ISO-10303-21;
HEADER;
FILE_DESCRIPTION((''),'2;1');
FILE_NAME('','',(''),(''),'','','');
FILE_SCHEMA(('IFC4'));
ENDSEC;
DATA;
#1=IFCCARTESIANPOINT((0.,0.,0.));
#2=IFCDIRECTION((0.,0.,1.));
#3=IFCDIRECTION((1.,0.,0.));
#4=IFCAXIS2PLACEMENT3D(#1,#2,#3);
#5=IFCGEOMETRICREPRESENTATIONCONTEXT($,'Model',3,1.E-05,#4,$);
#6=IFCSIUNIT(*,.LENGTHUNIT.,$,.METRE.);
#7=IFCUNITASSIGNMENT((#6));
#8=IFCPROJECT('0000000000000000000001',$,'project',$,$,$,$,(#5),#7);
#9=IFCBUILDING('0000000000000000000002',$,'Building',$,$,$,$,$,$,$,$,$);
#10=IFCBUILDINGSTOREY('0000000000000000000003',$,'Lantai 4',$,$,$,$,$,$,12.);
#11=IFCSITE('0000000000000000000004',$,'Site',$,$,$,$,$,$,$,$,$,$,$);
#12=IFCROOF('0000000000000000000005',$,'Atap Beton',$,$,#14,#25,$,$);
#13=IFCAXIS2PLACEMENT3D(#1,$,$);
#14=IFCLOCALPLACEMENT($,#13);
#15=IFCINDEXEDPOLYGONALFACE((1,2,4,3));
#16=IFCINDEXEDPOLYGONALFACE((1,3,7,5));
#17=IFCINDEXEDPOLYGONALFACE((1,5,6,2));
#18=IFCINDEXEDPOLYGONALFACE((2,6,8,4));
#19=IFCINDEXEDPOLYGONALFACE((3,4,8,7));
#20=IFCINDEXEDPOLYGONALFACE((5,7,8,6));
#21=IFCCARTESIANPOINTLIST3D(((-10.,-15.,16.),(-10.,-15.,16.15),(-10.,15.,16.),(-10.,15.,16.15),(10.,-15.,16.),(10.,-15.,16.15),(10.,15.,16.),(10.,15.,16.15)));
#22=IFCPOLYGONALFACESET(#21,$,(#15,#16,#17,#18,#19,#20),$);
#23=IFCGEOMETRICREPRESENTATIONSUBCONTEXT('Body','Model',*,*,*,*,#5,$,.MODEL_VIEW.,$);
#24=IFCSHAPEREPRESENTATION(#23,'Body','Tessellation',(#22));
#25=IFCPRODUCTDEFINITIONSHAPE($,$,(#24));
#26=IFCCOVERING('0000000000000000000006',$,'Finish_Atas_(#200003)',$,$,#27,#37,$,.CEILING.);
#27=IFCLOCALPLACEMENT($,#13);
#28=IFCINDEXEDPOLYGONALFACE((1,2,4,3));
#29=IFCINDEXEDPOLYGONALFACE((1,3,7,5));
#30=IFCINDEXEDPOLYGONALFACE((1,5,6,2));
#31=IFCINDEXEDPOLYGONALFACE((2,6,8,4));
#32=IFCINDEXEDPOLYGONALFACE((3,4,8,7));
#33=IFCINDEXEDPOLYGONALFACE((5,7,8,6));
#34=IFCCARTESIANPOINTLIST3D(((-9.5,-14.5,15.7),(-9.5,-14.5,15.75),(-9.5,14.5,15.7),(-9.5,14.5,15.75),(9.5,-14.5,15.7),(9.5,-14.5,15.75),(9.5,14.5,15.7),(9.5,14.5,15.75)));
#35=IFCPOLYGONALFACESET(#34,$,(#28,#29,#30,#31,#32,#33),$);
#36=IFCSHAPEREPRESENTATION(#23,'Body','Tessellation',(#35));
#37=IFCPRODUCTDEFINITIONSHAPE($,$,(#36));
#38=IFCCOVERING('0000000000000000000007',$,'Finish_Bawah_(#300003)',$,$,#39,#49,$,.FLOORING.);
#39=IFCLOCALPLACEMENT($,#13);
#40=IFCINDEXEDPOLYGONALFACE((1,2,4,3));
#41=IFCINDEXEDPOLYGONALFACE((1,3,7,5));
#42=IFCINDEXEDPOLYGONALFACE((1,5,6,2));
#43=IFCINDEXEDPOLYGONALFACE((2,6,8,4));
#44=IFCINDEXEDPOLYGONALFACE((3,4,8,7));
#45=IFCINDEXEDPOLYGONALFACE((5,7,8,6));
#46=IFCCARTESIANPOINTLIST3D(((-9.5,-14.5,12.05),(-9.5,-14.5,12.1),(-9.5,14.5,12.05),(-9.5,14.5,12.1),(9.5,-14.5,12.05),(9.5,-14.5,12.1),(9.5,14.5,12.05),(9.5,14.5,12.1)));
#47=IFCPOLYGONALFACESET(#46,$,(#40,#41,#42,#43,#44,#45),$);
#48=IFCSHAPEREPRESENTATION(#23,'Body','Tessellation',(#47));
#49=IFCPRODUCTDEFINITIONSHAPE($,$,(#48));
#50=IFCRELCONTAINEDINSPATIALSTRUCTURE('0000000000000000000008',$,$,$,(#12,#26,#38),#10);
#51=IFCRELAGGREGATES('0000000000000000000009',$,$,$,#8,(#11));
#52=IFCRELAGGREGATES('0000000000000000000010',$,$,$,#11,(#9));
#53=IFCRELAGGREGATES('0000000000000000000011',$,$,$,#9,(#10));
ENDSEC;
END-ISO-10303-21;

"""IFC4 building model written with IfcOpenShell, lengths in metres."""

from ifc_helpers import new_model, si_unit, frame, origin_with_axes, place, context, subcontext, project, spatial, polyline, outline, extrude, element, save


model = new_model("IFC4")

# Units and contexts
model_context = context("Model", 3, precision=1e-05, world=origin_with_axes())
body_context = subcontext(model_context, "Body", "Model", "MODEL_VIEW")
ifc_project = project(units=[si_unit("LENGTHUNIT", "METRE")], contexts=[model_context])

# Site, building, storey
site = spatial("IfcSite", under=ifc_project, Name="Site")
building = spatial("IfcBuilding", under=site, Name="Building")
storey = spatial("IfcBuildingStorey", under=building, Name="Lantai 4", Elevation=12.0)

# Roof
roof_placement = place(None, origin_with_axes())
element("IfcRoof", 1, at=roof_placement, inside=storey, Name="Atap Beton", context=body_context, shape_type="SweptSolid", body=[
    extrude(outline(polyline([(-10.0, -15.0), (10.0, -15.0), (10.0, 15.0), (-10.0, 15.0), (-10.0, -15.0)])), frame((0.0, 0.0, 16.0), z_axis=(0.0, 0.0, 1.0), x_axis=(1.0, 0.0, 0.0)), (0.0, 0.0, 1.0), 0.15),
])

# Coverings
covering_1_placement = place(None, origin_with_axes())
element("IfcCovering", 2, at=covering_1_placement, inside=storey, Name="Finish_Atas_(#200003)", PredefinedType="CEILING", context=body_context, shape_type="SweptSolid", body=[
    extrude(outline(polyline([(-9.5, -14.5), (9.5, -14.5), (9.5, 14.5), (-9.5, 14.5), (-9.5, -14.5)])), frame((0.0, 0.0, 15.7), z_axis=(0.0, 0.0, 1.0), x_axis=(1.0, 0.0, 0.0)), (0.0, 0.0, 1.0), 0.05),
])
covering_2_placement = place(None, origin_with_axes())
element("IfcCovering", 3, at=covering_2_placement, inside=storey, Name="Finish_Bawah_(#300003)", PredefinedType="FLOORING", context=body_context, shape_type="SweptSolid", body=[
    extrude(outline(polyline([(-9.5, -14.5), (9.5, -14.5), (9.5, 14.5), (-9.5, 14.5), (-9.5, -14.5)])), frame((0.0, 0.0, 12.05), z_axis=(0.0, 0.0, 1.0), x_axis=(1.0, 0.0, 0.0)), (0.0, 0.0, 1.0), 0.05),
])

save(model, "model.ifc")
